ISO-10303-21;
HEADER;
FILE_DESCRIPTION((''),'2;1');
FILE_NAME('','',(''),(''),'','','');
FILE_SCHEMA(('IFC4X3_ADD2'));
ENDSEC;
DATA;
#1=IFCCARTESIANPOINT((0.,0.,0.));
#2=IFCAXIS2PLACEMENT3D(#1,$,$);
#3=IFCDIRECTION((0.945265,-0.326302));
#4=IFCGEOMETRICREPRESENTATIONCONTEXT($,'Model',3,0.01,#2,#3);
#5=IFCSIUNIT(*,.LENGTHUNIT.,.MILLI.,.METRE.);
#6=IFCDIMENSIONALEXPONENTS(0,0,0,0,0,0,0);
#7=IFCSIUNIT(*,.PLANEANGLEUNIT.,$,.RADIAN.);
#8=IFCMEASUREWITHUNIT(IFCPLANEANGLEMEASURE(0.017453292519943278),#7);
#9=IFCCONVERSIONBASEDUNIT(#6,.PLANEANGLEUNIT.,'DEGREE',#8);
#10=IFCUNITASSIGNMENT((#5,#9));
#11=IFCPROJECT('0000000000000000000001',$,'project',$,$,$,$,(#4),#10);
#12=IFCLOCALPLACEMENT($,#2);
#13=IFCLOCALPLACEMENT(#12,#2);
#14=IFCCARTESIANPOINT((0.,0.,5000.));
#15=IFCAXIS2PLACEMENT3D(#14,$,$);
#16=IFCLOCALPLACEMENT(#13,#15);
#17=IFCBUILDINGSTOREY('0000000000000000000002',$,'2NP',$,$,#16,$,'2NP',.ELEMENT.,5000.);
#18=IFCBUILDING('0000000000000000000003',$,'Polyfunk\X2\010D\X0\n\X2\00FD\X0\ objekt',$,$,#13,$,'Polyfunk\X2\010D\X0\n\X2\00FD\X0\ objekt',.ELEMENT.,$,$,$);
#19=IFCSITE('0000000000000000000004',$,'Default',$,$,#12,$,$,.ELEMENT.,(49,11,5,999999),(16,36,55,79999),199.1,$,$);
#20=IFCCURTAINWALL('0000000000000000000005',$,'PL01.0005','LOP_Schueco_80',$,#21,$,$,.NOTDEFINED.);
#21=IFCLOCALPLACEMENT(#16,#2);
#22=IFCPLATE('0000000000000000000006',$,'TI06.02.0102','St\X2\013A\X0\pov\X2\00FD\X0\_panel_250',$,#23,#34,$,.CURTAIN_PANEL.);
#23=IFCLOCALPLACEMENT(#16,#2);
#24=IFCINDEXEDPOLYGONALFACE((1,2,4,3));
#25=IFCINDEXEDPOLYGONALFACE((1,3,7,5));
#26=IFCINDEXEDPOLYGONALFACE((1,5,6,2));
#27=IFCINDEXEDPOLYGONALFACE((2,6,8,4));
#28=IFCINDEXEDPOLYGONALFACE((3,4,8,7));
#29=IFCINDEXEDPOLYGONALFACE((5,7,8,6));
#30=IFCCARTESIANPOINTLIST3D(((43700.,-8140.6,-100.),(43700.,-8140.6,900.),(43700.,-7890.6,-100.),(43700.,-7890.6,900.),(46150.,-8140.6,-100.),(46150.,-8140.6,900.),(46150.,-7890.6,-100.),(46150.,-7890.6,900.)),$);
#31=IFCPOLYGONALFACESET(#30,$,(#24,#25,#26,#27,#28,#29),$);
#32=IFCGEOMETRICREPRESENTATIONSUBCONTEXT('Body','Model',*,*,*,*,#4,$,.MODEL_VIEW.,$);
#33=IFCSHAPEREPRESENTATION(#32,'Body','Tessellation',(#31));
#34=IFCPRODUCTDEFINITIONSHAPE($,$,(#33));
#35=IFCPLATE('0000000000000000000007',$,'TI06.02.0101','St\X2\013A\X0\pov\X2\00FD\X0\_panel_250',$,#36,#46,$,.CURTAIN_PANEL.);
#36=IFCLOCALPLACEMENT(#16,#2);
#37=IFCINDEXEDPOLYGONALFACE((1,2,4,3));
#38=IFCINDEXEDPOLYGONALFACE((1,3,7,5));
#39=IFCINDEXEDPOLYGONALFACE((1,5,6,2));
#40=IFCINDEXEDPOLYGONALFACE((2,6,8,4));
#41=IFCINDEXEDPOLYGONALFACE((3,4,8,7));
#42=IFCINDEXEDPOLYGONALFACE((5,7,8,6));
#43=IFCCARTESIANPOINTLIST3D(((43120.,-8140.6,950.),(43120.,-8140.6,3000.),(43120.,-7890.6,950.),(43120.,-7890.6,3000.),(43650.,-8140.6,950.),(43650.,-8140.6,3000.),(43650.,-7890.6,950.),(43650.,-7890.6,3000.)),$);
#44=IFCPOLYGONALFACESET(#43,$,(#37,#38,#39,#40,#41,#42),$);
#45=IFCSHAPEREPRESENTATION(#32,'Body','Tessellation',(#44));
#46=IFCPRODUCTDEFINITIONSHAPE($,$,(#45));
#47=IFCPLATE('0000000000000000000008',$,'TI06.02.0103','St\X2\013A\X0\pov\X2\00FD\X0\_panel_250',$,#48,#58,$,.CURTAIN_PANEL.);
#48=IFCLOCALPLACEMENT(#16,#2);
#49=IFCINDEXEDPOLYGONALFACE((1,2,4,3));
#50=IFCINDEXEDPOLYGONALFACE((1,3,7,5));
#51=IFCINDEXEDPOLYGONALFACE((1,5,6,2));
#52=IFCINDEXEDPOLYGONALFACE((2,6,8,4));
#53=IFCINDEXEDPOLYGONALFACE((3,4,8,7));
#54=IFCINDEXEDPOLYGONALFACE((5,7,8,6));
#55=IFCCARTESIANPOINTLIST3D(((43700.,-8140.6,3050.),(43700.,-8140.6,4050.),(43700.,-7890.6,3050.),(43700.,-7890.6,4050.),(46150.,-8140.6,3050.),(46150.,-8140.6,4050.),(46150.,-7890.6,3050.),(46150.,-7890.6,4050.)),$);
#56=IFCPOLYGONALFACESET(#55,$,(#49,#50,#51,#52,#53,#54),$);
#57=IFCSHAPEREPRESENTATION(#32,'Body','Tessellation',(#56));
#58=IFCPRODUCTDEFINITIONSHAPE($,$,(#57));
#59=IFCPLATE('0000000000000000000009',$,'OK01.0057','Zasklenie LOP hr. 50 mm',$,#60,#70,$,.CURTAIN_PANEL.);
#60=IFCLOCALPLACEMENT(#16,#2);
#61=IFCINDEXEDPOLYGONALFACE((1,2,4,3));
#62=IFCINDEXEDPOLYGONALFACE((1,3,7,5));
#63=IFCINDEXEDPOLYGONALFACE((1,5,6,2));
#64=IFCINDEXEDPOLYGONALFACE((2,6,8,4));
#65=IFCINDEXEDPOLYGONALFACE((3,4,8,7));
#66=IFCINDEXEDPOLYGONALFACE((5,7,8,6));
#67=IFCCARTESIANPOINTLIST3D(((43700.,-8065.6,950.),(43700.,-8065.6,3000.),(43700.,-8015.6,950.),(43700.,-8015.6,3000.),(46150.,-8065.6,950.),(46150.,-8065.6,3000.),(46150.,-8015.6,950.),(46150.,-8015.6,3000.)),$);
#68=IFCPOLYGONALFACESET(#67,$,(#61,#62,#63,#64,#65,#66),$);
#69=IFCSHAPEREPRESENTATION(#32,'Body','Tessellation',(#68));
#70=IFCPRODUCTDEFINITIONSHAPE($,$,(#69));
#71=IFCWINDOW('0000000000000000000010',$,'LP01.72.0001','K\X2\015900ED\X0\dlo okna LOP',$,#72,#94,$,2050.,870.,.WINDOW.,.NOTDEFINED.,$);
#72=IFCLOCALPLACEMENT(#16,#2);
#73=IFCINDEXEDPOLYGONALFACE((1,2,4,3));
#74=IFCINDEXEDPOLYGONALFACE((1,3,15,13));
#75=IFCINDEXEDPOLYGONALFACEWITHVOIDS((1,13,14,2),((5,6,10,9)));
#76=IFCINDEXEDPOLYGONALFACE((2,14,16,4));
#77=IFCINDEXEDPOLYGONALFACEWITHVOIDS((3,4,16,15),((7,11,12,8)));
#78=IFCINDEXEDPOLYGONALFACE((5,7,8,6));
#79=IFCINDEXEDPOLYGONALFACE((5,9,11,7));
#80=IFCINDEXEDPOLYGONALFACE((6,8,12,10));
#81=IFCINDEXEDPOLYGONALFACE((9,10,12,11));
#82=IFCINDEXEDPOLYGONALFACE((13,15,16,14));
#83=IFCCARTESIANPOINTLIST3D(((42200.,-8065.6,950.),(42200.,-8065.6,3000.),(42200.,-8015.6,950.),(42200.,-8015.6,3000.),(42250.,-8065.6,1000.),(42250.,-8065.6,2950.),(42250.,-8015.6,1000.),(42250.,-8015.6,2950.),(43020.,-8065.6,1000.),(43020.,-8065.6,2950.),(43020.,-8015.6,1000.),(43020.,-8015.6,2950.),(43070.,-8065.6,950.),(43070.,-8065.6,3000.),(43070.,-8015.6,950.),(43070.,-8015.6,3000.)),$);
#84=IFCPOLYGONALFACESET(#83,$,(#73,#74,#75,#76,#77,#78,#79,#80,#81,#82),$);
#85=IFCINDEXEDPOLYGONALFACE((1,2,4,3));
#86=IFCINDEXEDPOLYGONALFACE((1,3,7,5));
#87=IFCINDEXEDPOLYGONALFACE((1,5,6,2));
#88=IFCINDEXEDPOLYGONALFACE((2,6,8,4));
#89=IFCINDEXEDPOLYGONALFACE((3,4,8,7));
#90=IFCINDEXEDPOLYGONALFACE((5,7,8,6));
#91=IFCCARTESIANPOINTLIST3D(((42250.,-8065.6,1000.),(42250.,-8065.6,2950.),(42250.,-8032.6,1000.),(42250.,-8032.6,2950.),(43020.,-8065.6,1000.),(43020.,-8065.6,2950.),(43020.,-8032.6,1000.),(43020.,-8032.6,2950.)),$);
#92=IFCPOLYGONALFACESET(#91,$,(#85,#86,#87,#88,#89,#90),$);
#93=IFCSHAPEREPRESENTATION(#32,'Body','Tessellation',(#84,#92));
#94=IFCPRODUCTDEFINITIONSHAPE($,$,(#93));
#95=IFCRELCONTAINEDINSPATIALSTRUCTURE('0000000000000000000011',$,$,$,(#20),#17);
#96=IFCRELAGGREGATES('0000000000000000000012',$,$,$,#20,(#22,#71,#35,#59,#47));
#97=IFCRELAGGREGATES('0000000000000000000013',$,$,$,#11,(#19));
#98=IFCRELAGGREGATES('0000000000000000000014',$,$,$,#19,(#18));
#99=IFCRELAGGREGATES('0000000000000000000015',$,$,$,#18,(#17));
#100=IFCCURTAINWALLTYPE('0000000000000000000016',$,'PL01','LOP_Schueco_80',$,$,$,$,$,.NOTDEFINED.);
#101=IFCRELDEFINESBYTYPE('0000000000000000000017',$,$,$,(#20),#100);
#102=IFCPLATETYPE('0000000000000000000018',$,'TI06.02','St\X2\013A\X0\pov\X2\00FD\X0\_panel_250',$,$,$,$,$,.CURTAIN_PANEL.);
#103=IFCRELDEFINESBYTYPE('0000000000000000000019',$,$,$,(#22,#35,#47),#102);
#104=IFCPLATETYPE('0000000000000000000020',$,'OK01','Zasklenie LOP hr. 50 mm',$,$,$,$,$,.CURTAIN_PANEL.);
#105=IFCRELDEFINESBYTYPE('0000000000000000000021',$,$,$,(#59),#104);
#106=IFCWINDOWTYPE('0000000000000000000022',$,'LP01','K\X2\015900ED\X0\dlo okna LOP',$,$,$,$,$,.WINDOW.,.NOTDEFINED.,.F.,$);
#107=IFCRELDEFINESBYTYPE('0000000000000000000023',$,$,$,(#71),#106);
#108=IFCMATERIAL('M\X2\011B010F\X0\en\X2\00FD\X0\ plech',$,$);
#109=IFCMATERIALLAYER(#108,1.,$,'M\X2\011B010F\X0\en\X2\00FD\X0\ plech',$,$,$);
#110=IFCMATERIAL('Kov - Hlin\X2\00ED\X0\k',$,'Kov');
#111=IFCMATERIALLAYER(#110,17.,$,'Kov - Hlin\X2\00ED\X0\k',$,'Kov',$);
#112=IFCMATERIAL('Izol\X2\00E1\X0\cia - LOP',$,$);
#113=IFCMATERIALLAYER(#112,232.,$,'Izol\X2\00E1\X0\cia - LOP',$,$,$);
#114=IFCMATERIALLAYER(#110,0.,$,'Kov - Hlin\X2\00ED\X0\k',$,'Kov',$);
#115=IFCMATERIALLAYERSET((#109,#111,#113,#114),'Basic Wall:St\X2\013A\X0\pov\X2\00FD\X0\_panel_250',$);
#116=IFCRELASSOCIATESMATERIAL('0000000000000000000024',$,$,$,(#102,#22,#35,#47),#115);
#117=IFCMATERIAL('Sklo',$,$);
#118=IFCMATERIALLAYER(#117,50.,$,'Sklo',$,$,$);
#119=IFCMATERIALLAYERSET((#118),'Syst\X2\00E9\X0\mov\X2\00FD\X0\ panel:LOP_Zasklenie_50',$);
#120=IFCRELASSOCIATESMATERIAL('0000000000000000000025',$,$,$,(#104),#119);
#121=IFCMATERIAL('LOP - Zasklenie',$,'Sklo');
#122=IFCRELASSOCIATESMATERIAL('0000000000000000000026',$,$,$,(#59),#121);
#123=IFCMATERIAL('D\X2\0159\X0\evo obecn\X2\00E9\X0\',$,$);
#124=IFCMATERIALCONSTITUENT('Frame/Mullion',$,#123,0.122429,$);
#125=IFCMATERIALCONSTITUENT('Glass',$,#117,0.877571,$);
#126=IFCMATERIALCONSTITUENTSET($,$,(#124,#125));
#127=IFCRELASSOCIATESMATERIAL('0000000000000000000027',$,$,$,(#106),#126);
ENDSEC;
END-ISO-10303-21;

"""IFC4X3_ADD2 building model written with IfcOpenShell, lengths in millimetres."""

from ifc_helpers import new_model, entity, si_unit, converted_unit, direction, frame, frame_2d, origin, origin_2d_with_axis, place, context, subcontext, project, spatial, polyline, rectangle, outline, extrude, source, transform, mapped, material, layer, layer_set, layer_usage, constituent, constituent_set, type_object, type_shapes, element, aggregate, save


model = new_model("IFC4X3_ADD2")

# Units and contexts
model_context = context("Model", 3, precision=0.01, world=origin(), true_north=direction((0.945265, -0.326302)))
body_context = subcontext(model_context, "Body", "Model", "MODEL_VIEW")
ifc_project = project(units=[si_unit("LENGTHUNIT", "METRE", prefix="MILLI"), converted_unit("PLANEANGLEUNIT", "DEGREE", entity("IfcPlaneAngleMeasure", 0.017453292519943278), si_unit("PLANEANGLEUNIT", "RADIAN"), dimensions=[0, 0, 0, 0, 0, 0, 0])], contexts=[model_context])

# Site, building, storey
site_placement = place(None, origin())
site = spatial("IfcSite", under=ifc_project, at=site_placement, Name="Default", CompositionType="ELEMENT", RefLatitude=(49, 11, 5, 999999), RefLongitude=(16, 36, 55, 79999), RefElevation=199.1)
building_placement = place(site_placement, origin())
building = spatial("IfcBuilding", under=site, at=building_placement, Name="Polyfunkčný objekt", LongName="Polyfunkčný objekt", CompositionType="ELEMENT")
storey_placement = place(building_placement, frame((0.0, 0.0, 5000.0)))
storey = spatial("IfcBuildingStorey", under=building, at=storey_placement, Name="2NP", LongName="2NP", CompositionType="ELEMENT", Elevation=5000.0)

# Curtain wall, plates, window
curtain_wall_type = type_object("IfcCurtainWallType", Name="PL01", Description="LOP_Schueco_80", PredefinedType="NOTDEFINED")
curtain_wall_placement = place(storey_placement, frame((0.0, 0.0, -5000.0)))
curtain_wall = element("IfcCurtainWall", 1, at=curtain_wall_placement, inside=storey, type_object=curtain_wall_type, Name="PL01.0005", Description="LOP_Schueco_80", PredefinedType="NOTDEFINED")
ifc_material_1 = material(Name="Měďený plech")
ifc_layer_1 = layer(ifc_material_1, 1.0, Name="Měďený plech")
ifc_material_2 = material(Name="Kov - Hliník", Category="Kov")
ifc_layer_2 = layer(ifc_material_2, 17.0, Name="Kov - Hliník", Category="Kov")
ifc_material_3 = material(Name="Izolácia - LOP")
ifc_layer_3 = layer(ifc_material_3, 232.0, Name="Izolácia - LOP")
ifc_layer_4 = layer(ifc_material_2, 0.0, Name="Kov - Hliník", Category="Kov")
ifc_layer_set_1 = layer_set([ifc_layer_1, ifc_layer_2, ifc_layer_3, ifc_layer_4], Name="Basic Wall:Stĺpový_panel_250")
ifc_layer_usage_1 = layer_usage(ifc_layer_set_1, "AXIS2", "POSITIVE", -125.0)
plate_type_1 = type_object("IfcPlateType", Name="TI06.02", Description="Stĺpový_panel_250", PredefinedType="CURTAIN_PANEL", material=ifc_layer_set_1)
plate_1_placement = place(storey_placement, frame((43700.0, -8015.6, -100.0)))
plate_1 = element("IfcPlate", 2, at=plate_1_placement, type_object=plate_type_1, material=ifc_layer_usage_1, Name="TI06.02.0102", Description="Stĺpový_panel_250", PredefinedType="CURTAIN_PANEL", context=body_context, shape_type="SweptSolid", body=[
    extrude(rectangle(XDim=250.0, YDim=2450.0, at=frame_2d((0.0, 0.0), x_axis=(1.0, 0.0))), frame((1225.0, 0.0, 0.0), z_axis=(0.0, 0.0, 1.0), x_axis=(0.0, 1.0, 0.0)), (0.0, 0.0, 1.0), 1000.0),
])
ifc_layer_usage_2 = layer_usage(ifc_layer_set_1, "AXIS2", "POSITIVE", -125.0)
plate_2_placement = place(storey_placement, frame((43120.0, -8015.6, 950.0)))
plate_2 = element("IfcPlate", 3, at=plate_2_placement, type_object=plate_type_1, material=ifc_layer_usage_2, Name="TI06.02.0101", Description="Stĺpový_panel_250", PredefinedType="CURTAIN_PANEL", context=body_context, shape_type="SweptSolid", body=[
    extrude(rectangle(XDim=250.0, YDim=530.0, at=frame_2d((0.0, 0.0), x_axis=(1.0, 0.0))), frame((265.0, 0.0, 0.0), z_axis=(0.0, 0.0, 1.0), x_axis=(0.0, 1.0, 0.0)), (0.0, 0.0, 1.0), 2050.0),
])
ifc_layer_usage_3 = layer_usage(ifc_layer_set_1, "AXIS2", "POSITIVE", -125.0)
plate_3_placement = place(storey_placement, frame((43700.0, -8015.6, 3050.0)))
plate_3 = element("IfcPlate", 4, at=plate_3_placement, type_object=plate_type_1, material=ifc_layer_usage_3, Name="TI06.02.0103", Description="Stĺpový_panel_250", PredefinedType="CURTAIN_PANEL", context=body_context, shape_type="SweptSolid", body=[
    extrude(rectangle(XDim=250.0, YDim=2450.0, at=frame_2d((0.0, 0.0), x_axis=(1.0, 0.0))), frame((1225.0, 0.0, 0.0), z_axis=(0.0, 0.0, 1.0), x_axis=(0.0, 1.0, 0.0)), (0.0, 0.0, 1.0), 1000.0),
])
ifc_material_4 = material(Name="LOP - Zasklenie", Category="Sklo")
ifc_material_5 = material(Name="Sklo")
ifc_layer_5 = layer(ifc_material_5, 50.0, Name="Sklo")
ifc_layer_set_2 = layer_set([ifc_layer_5], Name="Systémový panel:LOP_Zasklenie_50")
plate_type_2 = type_object("IfcPlateType", Name="OK01", Description="Zasklenie LOP hr. 50 mm", PredefinedType="CURTAIN_PANEL", material=ifc_layer_set_2)
shared_shape_1 = source(origin(), body_context, "Body", "SweptSolid", [
    extrude(rectangle(XDim=50.0, YDim=2450.0, at=origin_2d_with_axis()), frame((0.0, -25.0, 0.0), z_axis=(0.0, 0.0, 1.0), x_axis=(0.0, 1.0, 0.0)), (0.0, 0.0, 1.0), 2050.0),
])
type_shapes(plate_type_2, [shared_shape_1])
plate_4_placement = place(curtain_wall_placement, frame((44925.0, -8015.6, 5950.0)))
plate_4 = element("IfcPlate", 5, at=plate_4_placement, type_object=plate_type_2, material=ifc_material_4, Name="OK01.0057", Description="Zasklenie LOP hr. 50 mm", PredefinedType="CURTAIN_PANEL", context=body_context, shape_type="MappedRepresentation", body=[
    mapped(shared_shape_1, transform((0.0, 0.0, 0.0), scale=1.0)),
])
ifc_material_6 = material(Name="Dřevo obecné")
ifc_constituent_1 = constituent(ifc_material_6, Name="Frame/Mullion", fraction=0.122429)
ifc_constituent_2 = constituent(ifc_material_5, Name="Glass", fraction=0.877571)
ifc_constituent_set = constituent_set(constituents=[ifc_constituent_1, ifc_constituent_2])
window_type = type_object("IfcWindowType", Name="LP01", Description="Křídlo okna LOP", ParameterTakesPrecedence=False, PartitioningType="NOTDEFINED", PredefinedType="WINDOW", material=ifc_constituent_set)
shared_shape_2 = source(origin(), body_context, "Body", "SweptSolid", [
    extrude(outline(polyline([(-1025.0, -435.0), (1025.0, -435.0), (1025.0, 435.0), (-1025.0, 435.0), (-1025.0, -435.0)]), holes=[polyline([(-975.0, -385.0), (-975.0, 385.0), (975.0, 385.0), (975.0, -385.0), (-975.0, -385.0)])]), frame((0.0, 50.0, 1025.0), z_axis=(0.0, -1.0, 0.0), x_axis=(0.0, 0.0, -1.0)), (0.0, 0.0, 1.0), 50.0),
    extrude(rectangle(XDim=770.0, YDim=33.0, at=frame_2d((0.0, 0.0), x_axis=(1.0, 0.0))), frame((0.0, 33.5, 50.0), z_axis=(0.0, 0.0, 1.0), x_axis=(-1.0, 0.0, 0.0)), (0.0, 0.0, 1.0), 1950.0),
])
type_shapes(window_type, [shared_shape_2])
window_placement = place(curtain_wall_placement, frame((42635.0, -8015.6, 5950.0), z_axis=(0.0, 0.0, 1.0), x_axis=(-1.0, 0.0, 0.0)))
window = element("IfcWindow", 6, at=window_placement, type_object=window_type, Name="LP01.72.0001", Description="Křídlo okna LOP", OverallHeight=2050.0, OverallWidth=870.0, PartitioningType="NOTDEFINED", PredefinedType="WINDOW", context=body_context, shape_type="MappedRepresentation", body=[
    mapped(shared_shape_2, transform((0.0, 0.0, 0.0), scale=1.0)),
])
aggregate(curtain_wall, [plate_1, window, plate_2, plate_4, plate_3])

save(model, "model.ifc")
